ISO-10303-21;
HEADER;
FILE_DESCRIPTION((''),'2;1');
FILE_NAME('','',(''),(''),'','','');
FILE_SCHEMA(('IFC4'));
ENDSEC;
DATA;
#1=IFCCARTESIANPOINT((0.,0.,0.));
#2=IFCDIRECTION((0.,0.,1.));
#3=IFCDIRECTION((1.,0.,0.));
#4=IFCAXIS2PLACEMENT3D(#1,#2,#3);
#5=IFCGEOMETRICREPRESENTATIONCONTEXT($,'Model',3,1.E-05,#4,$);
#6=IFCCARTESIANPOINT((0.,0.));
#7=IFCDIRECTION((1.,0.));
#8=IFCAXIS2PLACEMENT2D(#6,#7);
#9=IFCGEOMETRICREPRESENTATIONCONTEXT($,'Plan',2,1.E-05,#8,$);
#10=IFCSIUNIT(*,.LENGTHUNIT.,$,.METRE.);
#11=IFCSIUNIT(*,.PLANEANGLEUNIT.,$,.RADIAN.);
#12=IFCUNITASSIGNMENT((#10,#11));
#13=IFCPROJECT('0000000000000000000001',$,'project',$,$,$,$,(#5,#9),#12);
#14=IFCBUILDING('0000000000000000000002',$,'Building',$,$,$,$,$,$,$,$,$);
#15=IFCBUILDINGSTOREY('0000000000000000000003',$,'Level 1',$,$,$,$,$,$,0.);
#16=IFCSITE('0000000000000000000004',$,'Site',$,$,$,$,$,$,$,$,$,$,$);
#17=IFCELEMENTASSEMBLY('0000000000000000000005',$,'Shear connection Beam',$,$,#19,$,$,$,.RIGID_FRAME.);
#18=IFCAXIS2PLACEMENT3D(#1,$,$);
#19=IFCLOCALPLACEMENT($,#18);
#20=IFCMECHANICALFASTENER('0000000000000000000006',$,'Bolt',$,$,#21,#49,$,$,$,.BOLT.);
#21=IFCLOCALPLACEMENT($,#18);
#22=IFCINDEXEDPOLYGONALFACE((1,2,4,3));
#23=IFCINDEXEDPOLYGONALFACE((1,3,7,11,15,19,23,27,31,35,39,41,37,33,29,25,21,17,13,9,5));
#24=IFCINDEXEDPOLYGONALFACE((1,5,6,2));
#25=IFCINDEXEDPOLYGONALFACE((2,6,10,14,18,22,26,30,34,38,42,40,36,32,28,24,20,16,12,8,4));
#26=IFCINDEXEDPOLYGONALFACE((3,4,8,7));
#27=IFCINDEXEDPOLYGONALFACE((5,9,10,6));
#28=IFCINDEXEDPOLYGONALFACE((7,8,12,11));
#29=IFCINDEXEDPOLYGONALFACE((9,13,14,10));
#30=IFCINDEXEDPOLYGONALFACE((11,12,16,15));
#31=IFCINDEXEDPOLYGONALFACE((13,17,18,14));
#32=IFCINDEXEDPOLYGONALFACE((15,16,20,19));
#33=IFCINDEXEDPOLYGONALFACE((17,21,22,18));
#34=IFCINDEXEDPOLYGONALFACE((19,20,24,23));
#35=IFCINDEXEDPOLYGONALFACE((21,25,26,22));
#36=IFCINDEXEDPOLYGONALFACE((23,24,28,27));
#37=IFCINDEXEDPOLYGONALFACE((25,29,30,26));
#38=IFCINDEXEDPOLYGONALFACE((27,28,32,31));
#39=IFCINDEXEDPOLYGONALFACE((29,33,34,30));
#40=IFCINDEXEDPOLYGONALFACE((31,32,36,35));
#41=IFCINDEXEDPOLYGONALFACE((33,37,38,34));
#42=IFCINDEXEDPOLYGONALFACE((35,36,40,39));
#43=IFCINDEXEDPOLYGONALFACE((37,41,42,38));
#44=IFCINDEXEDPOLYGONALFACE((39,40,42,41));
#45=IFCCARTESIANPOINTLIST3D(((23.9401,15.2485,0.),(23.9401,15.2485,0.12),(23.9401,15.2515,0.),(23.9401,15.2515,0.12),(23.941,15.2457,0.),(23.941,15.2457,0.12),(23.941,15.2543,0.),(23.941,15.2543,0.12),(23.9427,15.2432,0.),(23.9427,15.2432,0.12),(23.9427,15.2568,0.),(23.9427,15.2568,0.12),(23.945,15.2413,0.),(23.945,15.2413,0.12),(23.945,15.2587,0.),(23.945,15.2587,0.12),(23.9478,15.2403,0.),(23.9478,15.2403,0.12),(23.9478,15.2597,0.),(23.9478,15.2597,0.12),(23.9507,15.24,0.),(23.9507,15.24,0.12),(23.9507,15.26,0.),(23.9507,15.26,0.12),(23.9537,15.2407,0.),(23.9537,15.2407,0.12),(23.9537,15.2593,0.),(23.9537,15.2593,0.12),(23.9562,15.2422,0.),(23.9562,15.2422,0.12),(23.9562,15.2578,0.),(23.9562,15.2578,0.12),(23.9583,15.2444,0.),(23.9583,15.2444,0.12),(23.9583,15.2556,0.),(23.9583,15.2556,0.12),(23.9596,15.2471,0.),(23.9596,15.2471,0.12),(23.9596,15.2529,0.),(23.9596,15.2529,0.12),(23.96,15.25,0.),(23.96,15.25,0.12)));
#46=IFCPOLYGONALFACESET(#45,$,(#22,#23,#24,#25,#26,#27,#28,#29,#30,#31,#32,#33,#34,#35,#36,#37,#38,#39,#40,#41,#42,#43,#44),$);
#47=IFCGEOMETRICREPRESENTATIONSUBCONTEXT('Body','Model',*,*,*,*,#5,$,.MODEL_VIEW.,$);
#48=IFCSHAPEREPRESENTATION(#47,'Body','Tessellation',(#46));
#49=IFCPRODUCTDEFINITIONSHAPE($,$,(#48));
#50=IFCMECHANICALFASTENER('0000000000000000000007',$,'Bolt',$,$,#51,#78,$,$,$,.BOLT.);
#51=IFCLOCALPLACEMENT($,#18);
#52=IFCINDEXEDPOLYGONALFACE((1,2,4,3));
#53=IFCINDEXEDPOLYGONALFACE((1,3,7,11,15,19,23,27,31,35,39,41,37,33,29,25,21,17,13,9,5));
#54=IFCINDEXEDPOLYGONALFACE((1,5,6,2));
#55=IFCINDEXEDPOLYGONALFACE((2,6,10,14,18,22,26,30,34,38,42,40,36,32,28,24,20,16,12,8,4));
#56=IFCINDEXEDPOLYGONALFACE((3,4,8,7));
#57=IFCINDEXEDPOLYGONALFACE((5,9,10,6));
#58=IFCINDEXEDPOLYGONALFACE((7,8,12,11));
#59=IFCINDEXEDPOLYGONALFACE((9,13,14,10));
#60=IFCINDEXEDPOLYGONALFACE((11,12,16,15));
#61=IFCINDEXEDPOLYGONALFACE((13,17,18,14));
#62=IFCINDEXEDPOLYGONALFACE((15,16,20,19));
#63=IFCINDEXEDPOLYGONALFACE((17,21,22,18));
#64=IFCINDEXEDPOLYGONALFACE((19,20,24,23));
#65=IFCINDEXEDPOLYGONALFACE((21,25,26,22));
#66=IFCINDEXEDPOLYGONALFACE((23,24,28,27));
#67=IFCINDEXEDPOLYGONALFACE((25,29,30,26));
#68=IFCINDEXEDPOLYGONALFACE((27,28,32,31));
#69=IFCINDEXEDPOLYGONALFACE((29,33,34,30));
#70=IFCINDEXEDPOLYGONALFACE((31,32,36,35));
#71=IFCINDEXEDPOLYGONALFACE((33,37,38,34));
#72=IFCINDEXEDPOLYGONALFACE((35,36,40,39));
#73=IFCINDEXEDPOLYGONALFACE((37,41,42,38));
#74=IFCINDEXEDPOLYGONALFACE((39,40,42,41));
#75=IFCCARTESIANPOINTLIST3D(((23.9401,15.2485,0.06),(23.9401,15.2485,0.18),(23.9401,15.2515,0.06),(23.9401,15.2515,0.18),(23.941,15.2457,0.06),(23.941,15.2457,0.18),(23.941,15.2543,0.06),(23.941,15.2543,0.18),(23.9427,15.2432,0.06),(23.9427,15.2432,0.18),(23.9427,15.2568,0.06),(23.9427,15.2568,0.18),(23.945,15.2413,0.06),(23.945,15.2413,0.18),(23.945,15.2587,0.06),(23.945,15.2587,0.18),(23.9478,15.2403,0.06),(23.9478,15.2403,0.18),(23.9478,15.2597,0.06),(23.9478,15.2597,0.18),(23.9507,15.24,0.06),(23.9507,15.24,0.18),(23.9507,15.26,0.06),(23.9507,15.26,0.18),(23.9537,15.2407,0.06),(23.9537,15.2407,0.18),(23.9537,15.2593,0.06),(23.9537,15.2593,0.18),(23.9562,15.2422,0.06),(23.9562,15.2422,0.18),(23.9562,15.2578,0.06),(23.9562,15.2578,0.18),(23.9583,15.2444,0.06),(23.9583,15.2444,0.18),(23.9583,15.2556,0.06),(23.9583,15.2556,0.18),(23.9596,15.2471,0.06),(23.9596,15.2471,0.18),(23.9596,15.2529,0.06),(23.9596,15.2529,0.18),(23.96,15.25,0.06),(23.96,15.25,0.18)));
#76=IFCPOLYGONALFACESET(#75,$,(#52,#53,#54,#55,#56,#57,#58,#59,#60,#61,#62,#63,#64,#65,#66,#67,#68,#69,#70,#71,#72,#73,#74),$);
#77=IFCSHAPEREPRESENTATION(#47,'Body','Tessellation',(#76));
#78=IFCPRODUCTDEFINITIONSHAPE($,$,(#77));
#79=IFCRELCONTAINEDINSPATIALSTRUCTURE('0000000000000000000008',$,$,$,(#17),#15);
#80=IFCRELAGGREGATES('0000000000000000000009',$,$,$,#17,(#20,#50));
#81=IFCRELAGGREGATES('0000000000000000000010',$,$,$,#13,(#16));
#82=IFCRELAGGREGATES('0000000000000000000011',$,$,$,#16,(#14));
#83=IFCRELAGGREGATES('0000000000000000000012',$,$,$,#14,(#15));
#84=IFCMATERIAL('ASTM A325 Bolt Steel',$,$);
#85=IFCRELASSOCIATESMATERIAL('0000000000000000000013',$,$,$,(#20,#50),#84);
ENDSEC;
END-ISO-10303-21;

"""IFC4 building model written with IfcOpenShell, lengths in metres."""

from ifc_helpers import new_model, si_unit, frame, origin_with_axes, origin_2d, origin_2d_with_axis, place, context, subcontext, project, spatial, circle, extrude, material, element, aggregate, save


model = new_model("IFC4")

# Units and contexts
model_context = context("Model", 3, precision=1e-05, world=origin_with_axes())
plan_context = context("Plan", 2, precision=1e-05, world=origin_2d_with_axis())
body_context = subcontext(model_context, "Body", "Model", "MODEL_VIEW")
ifc_project = project(units=[si_unit("LENGTHUNIT", "METRE"), si_unit("PLANEANGLEUNIT", "RADIAN")], contexts=[model_context, plan_context])

# Site, building, storey
site = spatial("IfcSite", under=ifc_project, Name="Site")
building = spatial("IfcBuilding", under=site, Name="Building")
storey = spatial("IfcBuildingStorey", under=building, Name="Level 1", Elevation=0.0)

# Element assembly
assembly_1 = element("IfcElementAssembly", 1, inside=storey, Name="Shear connection Beam", PredefinedType="RIGID_FRAME")

# Shared definitions
ifc_material_1 = material(Name="ASTM A325 Bolt Steel")

# Mechanical fasteners
mechanical_fastener_1_placement = place(None, frame((23.95, 15.25, 0.0), z_axis=(0.0, 0.0, 1.0), x_axis=(1.0, 0.0, 0.0)))
mechanical_fastener_1 = element("IfcMechanicalFastener", 2, at=mechanical_fastener_1_placement, material=ifc_material_1, Name="Bolt", PredefinedType="BOLT", context=body_context, shape_type="SweptSolid", body=[
    extrude(circle(Radius=0.01, at=origin_2d()), origin_with_axes(), (0.0, 0.0, 1.0), 0.12),
])
mechanical_fastener_2_placement = place(None, frame((23.95, 15.25, 0.06), z_axis=(0.0, 0.0, 1.0), x_axis=(1.0, 0.0, 0.0)))
mechanical_fastener_2 = element("IfcMechanicalFastener", 3, at=mechanical_fastener_2_placement, material=ifc_material_1, Name="Bolt", PredefinedType="BOLT", context=body_context, shape_type="SweptSolid", body=[
    extrude(circle(Radius=0.01, at=origin_2d()), origin_with_axes(), (0.0, 0.0, 1.0), 0.12),
])
aggregate(assembly_1, [mechanical_fastener_1, mechanical_fastener_2])

save(model, "model.ifc")
